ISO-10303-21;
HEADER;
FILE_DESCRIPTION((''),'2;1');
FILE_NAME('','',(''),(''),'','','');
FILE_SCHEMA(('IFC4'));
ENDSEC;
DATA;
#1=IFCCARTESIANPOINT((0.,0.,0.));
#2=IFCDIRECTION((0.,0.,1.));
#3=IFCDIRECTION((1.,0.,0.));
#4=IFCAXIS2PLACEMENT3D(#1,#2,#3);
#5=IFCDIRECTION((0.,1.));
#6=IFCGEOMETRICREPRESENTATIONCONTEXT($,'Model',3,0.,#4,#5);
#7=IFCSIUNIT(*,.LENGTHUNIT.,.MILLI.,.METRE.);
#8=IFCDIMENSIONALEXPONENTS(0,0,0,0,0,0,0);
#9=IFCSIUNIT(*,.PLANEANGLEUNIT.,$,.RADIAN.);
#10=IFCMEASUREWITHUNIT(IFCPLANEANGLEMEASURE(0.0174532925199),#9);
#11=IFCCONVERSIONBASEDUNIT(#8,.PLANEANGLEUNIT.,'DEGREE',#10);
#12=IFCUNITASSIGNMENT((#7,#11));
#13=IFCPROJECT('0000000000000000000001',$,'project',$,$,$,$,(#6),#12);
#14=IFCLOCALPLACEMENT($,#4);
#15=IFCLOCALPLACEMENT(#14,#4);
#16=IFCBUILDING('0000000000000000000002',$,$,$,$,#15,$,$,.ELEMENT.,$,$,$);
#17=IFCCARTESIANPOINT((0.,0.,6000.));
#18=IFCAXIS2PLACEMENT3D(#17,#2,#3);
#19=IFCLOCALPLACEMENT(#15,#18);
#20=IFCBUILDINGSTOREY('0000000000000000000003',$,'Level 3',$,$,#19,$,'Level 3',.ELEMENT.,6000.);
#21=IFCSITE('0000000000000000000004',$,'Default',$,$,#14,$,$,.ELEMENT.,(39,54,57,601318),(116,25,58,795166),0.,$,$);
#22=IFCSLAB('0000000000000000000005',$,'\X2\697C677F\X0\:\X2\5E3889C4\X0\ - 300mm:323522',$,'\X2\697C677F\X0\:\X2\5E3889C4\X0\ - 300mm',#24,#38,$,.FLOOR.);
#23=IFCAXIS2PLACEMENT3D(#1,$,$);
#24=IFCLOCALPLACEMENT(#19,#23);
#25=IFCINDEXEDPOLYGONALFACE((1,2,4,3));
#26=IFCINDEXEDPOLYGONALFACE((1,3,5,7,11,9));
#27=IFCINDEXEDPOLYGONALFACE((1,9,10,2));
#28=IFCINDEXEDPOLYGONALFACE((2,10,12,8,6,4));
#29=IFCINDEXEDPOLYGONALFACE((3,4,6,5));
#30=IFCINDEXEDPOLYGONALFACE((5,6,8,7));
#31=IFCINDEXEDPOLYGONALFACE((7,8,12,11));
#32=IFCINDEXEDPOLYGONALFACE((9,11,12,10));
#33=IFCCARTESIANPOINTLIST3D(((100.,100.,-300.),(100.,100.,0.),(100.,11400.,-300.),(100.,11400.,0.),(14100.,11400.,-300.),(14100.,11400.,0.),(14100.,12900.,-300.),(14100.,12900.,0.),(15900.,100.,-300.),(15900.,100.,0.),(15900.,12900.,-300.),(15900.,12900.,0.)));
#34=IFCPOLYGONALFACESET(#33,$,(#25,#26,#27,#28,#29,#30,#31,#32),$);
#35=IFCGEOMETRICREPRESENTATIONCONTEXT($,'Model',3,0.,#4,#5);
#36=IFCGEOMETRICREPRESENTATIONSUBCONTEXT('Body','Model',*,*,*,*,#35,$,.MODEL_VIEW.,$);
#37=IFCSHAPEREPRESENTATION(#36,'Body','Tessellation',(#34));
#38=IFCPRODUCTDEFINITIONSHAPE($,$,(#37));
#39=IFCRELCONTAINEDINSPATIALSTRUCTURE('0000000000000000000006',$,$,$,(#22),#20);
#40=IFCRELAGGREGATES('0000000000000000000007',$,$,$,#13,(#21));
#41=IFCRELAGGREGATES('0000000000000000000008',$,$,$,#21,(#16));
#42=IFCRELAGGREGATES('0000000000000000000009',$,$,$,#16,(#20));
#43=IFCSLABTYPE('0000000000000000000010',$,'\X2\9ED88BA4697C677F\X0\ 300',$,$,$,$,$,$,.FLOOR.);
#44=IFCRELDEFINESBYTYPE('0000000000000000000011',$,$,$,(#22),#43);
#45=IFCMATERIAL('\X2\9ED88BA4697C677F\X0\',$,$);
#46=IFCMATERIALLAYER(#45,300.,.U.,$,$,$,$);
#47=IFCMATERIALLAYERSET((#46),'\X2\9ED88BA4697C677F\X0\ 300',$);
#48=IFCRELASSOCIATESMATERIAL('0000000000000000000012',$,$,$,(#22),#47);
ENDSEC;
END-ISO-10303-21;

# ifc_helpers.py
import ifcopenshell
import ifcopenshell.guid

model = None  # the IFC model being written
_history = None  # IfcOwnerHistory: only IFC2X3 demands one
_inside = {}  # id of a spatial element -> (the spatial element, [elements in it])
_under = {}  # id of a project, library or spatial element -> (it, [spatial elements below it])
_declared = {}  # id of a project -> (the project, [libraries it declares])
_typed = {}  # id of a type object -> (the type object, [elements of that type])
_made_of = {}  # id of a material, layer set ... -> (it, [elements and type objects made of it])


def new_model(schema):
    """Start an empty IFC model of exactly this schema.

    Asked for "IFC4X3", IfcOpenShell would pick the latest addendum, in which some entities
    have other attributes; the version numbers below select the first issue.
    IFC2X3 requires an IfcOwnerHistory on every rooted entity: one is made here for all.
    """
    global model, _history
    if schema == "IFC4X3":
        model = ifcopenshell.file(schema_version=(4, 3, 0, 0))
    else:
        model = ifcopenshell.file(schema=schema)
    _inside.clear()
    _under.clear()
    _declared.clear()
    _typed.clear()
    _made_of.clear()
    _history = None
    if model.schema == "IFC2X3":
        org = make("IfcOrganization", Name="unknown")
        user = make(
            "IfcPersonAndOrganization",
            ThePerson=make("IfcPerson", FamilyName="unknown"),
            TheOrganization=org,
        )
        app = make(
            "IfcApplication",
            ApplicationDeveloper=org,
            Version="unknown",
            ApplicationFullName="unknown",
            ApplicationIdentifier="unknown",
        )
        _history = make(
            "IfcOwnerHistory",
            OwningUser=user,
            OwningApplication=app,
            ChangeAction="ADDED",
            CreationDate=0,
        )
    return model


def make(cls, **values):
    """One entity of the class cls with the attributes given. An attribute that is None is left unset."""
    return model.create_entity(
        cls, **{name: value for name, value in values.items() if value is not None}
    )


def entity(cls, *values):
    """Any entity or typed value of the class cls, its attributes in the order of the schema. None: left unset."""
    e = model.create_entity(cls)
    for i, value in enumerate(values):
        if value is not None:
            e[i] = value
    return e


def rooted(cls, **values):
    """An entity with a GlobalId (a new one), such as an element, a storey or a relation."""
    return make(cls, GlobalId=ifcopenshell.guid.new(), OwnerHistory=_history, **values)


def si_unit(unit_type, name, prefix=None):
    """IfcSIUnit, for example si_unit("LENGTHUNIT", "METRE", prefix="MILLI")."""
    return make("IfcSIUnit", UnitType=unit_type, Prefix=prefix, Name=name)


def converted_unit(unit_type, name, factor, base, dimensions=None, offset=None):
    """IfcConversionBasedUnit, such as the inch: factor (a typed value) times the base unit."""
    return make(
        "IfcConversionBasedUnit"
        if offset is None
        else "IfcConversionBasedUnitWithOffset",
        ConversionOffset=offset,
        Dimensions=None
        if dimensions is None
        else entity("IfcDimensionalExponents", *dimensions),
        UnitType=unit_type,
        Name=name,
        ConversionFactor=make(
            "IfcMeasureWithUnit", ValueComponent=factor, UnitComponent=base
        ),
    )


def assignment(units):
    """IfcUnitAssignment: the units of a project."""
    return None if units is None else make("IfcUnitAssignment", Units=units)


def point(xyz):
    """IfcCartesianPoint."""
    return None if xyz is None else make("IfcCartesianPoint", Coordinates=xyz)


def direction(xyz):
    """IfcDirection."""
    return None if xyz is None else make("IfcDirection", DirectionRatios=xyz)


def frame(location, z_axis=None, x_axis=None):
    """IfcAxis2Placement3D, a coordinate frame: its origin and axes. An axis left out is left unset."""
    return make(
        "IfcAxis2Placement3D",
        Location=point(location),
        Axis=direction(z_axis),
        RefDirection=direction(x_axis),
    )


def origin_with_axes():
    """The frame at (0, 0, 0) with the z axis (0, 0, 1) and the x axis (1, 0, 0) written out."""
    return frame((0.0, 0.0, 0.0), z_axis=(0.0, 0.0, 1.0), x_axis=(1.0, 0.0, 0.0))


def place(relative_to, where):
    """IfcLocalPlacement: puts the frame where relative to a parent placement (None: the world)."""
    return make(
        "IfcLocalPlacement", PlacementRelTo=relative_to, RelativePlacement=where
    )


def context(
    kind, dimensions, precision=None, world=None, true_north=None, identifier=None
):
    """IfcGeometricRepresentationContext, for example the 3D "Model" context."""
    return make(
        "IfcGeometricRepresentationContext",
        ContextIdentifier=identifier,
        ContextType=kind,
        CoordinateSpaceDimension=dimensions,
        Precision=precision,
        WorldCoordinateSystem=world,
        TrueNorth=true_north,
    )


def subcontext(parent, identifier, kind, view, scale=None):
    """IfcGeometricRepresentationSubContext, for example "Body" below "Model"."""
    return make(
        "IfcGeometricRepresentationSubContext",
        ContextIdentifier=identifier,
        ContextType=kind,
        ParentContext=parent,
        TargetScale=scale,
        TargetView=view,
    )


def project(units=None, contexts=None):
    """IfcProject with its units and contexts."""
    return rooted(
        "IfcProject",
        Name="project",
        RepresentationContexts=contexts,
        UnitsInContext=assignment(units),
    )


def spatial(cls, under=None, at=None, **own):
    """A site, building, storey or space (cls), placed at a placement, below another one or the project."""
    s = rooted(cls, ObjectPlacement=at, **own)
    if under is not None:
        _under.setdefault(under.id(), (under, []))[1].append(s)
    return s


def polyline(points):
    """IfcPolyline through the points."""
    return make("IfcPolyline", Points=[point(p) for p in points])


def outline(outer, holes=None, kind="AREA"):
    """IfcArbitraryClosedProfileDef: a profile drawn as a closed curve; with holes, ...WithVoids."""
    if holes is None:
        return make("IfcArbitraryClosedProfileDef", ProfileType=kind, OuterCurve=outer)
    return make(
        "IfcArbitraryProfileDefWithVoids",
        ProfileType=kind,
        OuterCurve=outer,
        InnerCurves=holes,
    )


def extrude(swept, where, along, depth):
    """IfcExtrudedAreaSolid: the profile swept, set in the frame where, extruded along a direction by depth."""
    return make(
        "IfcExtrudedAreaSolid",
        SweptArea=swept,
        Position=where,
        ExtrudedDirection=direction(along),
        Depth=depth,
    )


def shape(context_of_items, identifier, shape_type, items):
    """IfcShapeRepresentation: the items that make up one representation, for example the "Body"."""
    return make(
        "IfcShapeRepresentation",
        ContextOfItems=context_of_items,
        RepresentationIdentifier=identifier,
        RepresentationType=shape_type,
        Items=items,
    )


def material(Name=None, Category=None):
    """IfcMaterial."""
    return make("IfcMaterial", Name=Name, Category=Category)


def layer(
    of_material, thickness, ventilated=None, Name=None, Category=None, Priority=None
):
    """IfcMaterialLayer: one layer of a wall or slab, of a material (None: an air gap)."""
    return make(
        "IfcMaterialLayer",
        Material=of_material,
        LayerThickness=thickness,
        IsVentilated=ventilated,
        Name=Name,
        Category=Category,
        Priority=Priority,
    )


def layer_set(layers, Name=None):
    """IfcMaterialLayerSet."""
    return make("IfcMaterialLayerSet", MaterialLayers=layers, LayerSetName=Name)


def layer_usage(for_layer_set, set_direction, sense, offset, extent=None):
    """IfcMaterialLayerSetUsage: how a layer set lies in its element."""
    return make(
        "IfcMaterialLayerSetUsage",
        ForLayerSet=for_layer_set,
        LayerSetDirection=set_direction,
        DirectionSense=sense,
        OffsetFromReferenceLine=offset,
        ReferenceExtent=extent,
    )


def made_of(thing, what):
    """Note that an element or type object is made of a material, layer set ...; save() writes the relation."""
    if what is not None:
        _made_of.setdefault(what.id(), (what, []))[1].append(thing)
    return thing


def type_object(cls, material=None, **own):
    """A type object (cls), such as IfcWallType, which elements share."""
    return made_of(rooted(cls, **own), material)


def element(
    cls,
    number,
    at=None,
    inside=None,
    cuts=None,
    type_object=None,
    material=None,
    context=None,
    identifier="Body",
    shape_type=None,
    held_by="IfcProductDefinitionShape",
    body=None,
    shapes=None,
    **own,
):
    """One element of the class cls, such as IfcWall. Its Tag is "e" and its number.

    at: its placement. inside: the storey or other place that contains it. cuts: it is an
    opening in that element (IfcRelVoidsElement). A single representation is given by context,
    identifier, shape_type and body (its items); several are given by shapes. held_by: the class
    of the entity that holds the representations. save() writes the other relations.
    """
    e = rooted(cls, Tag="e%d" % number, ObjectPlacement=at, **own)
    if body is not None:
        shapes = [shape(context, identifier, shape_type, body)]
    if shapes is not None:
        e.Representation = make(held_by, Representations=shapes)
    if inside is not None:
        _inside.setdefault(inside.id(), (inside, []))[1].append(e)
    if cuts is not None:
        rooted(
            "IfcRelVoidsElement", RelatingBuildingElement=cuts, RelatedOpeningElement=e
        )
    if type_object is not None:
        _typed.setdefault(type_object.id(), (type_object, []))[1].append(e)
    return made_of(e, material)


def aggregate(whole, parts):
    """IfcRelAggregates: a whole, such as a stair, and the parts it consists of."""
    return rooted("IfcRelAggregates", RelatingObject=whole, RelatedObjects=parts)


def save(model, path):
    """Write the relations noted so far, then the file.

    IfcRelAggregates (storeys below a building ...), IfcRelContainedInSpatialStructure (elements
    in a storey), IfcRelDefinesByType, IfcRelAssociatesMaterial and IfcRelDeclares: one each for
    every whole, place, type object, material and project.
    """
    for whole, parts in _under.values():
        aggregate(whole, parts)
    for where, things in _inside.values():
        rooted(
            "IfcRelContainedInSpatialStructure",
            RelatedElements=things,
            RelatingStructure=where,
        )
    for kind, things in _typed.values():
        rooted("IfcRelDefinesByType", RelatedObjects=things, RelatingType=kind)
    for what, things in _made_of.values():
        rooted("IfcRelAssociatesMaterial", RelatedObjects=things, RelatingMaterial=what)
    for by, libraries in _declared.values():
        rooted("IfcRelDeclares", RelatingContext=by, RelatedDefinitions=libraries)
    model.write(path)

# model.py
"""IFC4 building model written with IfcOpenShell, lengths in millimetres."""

from ifc_helpers import new_model, entity, si_unit, converted_unit, direction, frame, origin_with_axes, place, context, subcontext, project, spatial, polyline, outline, extrude, material, layer, layer_set, layer_usage, type_object, element, save


model = new_model("IFC4")

# Units and contexts
model_context_1 = context("Model", 3, precision=0.0, world=origin_with_axes(), true_north=direction((0.0, 1.0)))
model_context_2 = context("Model", 3, precision=0.0, world=origin_with_axes(), true_north=direction((0.0, 1.0)))
body_context = subcontext(model_context_2, "Body", "Model", "MODEL_VIEW")
ifc_project = project(units=[si_unit("LENGTHUNIT", "METRE", prefix="MILLI"), converted_unit("PLANEANGLEUNIT", "DEGREE", entity("IfcPlaneAngleMeasure", 0.0174532925199), si_unit("PLANEANGLEUNIT", "RADIAN"), dimensions=[0, 0, 0, 0, 0, 0, 0])], contexts=[model_context_1])

# Site, building, storey
site_placement = place(None, origin_with_axes())
site = spatial("IfcSite", under=ifc_project, at=site_placement, Name="Default", CompositionType="ELEMENT", RefLatitude=(39, 54, 57, 601318), RefLongitude=(116, 25, 58, 795166), RefElevation=0.0)
building_placement = place(site_placement, origin_with_axes())
building = spatial("IfcBuilding", under=site, at=building_placement, CompositionType="ELEMENT")
storey_placement = place(building_placement, frame((0.0, 0.0, 6000.0), z_axis=(0.0, 0.0, 1.0), x_axis=(1.0, 0.0, 0.0)))
storey = spatial("IfcBuildingStorey", under=building, at=storey_placement, Name="Level 3", LongName="Level 3", CompositionType="ELEMENT", Elevation=6000.0)

# Slab
ifc_material = material(Name="默认楼板")
ifc_layer = layer(ifc_material, 300.0, ventilated="UNKNOWN")
ifc_layer_set = layer_set([ifc_layer], Name="默认楼板 300")
ifc_layer_usage = layer_usage(ifc_layer_set, "AXIS3", "NEGATIVE", 300.0)
slab_type = type_object("IfcSlabType", Name="默认楼板 300", PredefinedType="FLOOR")
slab_placement = place(storey_placement, frame((100.0, 100.0, 0.0), z_axis=(0.0, 0.0, 1.0), x_axis=(1.0, 0.0, 0.0)))
element("IfcSlab", 1, at=slab_placement, inside=storey, type_object=slab_type, material=ifc_layer_usage, Name="楼板:常规 - 300mm:323522", ObjectType="楼板:常规 - 300mm", PredefinedType="FLOOR", context=body_context, shape_type="SweptSolid", body=[
    extrude(outline(polyline([(0.0, 0.0), (15800.0, 0.0), (15800.0, 12800.0), (14000.0, 12800.0), (14000.0, 11300.0), (0.0, 11300.0), (0.0, 0.0)])), frame((0.0, 0.0, -300.0), z_axis=(0.0, 0.0, 1.0), x_axis=(1.0, 0.0, 0.0)), (0.0, 0.0, 1.0), 300.0),
])

save(model, "model.ifc")
